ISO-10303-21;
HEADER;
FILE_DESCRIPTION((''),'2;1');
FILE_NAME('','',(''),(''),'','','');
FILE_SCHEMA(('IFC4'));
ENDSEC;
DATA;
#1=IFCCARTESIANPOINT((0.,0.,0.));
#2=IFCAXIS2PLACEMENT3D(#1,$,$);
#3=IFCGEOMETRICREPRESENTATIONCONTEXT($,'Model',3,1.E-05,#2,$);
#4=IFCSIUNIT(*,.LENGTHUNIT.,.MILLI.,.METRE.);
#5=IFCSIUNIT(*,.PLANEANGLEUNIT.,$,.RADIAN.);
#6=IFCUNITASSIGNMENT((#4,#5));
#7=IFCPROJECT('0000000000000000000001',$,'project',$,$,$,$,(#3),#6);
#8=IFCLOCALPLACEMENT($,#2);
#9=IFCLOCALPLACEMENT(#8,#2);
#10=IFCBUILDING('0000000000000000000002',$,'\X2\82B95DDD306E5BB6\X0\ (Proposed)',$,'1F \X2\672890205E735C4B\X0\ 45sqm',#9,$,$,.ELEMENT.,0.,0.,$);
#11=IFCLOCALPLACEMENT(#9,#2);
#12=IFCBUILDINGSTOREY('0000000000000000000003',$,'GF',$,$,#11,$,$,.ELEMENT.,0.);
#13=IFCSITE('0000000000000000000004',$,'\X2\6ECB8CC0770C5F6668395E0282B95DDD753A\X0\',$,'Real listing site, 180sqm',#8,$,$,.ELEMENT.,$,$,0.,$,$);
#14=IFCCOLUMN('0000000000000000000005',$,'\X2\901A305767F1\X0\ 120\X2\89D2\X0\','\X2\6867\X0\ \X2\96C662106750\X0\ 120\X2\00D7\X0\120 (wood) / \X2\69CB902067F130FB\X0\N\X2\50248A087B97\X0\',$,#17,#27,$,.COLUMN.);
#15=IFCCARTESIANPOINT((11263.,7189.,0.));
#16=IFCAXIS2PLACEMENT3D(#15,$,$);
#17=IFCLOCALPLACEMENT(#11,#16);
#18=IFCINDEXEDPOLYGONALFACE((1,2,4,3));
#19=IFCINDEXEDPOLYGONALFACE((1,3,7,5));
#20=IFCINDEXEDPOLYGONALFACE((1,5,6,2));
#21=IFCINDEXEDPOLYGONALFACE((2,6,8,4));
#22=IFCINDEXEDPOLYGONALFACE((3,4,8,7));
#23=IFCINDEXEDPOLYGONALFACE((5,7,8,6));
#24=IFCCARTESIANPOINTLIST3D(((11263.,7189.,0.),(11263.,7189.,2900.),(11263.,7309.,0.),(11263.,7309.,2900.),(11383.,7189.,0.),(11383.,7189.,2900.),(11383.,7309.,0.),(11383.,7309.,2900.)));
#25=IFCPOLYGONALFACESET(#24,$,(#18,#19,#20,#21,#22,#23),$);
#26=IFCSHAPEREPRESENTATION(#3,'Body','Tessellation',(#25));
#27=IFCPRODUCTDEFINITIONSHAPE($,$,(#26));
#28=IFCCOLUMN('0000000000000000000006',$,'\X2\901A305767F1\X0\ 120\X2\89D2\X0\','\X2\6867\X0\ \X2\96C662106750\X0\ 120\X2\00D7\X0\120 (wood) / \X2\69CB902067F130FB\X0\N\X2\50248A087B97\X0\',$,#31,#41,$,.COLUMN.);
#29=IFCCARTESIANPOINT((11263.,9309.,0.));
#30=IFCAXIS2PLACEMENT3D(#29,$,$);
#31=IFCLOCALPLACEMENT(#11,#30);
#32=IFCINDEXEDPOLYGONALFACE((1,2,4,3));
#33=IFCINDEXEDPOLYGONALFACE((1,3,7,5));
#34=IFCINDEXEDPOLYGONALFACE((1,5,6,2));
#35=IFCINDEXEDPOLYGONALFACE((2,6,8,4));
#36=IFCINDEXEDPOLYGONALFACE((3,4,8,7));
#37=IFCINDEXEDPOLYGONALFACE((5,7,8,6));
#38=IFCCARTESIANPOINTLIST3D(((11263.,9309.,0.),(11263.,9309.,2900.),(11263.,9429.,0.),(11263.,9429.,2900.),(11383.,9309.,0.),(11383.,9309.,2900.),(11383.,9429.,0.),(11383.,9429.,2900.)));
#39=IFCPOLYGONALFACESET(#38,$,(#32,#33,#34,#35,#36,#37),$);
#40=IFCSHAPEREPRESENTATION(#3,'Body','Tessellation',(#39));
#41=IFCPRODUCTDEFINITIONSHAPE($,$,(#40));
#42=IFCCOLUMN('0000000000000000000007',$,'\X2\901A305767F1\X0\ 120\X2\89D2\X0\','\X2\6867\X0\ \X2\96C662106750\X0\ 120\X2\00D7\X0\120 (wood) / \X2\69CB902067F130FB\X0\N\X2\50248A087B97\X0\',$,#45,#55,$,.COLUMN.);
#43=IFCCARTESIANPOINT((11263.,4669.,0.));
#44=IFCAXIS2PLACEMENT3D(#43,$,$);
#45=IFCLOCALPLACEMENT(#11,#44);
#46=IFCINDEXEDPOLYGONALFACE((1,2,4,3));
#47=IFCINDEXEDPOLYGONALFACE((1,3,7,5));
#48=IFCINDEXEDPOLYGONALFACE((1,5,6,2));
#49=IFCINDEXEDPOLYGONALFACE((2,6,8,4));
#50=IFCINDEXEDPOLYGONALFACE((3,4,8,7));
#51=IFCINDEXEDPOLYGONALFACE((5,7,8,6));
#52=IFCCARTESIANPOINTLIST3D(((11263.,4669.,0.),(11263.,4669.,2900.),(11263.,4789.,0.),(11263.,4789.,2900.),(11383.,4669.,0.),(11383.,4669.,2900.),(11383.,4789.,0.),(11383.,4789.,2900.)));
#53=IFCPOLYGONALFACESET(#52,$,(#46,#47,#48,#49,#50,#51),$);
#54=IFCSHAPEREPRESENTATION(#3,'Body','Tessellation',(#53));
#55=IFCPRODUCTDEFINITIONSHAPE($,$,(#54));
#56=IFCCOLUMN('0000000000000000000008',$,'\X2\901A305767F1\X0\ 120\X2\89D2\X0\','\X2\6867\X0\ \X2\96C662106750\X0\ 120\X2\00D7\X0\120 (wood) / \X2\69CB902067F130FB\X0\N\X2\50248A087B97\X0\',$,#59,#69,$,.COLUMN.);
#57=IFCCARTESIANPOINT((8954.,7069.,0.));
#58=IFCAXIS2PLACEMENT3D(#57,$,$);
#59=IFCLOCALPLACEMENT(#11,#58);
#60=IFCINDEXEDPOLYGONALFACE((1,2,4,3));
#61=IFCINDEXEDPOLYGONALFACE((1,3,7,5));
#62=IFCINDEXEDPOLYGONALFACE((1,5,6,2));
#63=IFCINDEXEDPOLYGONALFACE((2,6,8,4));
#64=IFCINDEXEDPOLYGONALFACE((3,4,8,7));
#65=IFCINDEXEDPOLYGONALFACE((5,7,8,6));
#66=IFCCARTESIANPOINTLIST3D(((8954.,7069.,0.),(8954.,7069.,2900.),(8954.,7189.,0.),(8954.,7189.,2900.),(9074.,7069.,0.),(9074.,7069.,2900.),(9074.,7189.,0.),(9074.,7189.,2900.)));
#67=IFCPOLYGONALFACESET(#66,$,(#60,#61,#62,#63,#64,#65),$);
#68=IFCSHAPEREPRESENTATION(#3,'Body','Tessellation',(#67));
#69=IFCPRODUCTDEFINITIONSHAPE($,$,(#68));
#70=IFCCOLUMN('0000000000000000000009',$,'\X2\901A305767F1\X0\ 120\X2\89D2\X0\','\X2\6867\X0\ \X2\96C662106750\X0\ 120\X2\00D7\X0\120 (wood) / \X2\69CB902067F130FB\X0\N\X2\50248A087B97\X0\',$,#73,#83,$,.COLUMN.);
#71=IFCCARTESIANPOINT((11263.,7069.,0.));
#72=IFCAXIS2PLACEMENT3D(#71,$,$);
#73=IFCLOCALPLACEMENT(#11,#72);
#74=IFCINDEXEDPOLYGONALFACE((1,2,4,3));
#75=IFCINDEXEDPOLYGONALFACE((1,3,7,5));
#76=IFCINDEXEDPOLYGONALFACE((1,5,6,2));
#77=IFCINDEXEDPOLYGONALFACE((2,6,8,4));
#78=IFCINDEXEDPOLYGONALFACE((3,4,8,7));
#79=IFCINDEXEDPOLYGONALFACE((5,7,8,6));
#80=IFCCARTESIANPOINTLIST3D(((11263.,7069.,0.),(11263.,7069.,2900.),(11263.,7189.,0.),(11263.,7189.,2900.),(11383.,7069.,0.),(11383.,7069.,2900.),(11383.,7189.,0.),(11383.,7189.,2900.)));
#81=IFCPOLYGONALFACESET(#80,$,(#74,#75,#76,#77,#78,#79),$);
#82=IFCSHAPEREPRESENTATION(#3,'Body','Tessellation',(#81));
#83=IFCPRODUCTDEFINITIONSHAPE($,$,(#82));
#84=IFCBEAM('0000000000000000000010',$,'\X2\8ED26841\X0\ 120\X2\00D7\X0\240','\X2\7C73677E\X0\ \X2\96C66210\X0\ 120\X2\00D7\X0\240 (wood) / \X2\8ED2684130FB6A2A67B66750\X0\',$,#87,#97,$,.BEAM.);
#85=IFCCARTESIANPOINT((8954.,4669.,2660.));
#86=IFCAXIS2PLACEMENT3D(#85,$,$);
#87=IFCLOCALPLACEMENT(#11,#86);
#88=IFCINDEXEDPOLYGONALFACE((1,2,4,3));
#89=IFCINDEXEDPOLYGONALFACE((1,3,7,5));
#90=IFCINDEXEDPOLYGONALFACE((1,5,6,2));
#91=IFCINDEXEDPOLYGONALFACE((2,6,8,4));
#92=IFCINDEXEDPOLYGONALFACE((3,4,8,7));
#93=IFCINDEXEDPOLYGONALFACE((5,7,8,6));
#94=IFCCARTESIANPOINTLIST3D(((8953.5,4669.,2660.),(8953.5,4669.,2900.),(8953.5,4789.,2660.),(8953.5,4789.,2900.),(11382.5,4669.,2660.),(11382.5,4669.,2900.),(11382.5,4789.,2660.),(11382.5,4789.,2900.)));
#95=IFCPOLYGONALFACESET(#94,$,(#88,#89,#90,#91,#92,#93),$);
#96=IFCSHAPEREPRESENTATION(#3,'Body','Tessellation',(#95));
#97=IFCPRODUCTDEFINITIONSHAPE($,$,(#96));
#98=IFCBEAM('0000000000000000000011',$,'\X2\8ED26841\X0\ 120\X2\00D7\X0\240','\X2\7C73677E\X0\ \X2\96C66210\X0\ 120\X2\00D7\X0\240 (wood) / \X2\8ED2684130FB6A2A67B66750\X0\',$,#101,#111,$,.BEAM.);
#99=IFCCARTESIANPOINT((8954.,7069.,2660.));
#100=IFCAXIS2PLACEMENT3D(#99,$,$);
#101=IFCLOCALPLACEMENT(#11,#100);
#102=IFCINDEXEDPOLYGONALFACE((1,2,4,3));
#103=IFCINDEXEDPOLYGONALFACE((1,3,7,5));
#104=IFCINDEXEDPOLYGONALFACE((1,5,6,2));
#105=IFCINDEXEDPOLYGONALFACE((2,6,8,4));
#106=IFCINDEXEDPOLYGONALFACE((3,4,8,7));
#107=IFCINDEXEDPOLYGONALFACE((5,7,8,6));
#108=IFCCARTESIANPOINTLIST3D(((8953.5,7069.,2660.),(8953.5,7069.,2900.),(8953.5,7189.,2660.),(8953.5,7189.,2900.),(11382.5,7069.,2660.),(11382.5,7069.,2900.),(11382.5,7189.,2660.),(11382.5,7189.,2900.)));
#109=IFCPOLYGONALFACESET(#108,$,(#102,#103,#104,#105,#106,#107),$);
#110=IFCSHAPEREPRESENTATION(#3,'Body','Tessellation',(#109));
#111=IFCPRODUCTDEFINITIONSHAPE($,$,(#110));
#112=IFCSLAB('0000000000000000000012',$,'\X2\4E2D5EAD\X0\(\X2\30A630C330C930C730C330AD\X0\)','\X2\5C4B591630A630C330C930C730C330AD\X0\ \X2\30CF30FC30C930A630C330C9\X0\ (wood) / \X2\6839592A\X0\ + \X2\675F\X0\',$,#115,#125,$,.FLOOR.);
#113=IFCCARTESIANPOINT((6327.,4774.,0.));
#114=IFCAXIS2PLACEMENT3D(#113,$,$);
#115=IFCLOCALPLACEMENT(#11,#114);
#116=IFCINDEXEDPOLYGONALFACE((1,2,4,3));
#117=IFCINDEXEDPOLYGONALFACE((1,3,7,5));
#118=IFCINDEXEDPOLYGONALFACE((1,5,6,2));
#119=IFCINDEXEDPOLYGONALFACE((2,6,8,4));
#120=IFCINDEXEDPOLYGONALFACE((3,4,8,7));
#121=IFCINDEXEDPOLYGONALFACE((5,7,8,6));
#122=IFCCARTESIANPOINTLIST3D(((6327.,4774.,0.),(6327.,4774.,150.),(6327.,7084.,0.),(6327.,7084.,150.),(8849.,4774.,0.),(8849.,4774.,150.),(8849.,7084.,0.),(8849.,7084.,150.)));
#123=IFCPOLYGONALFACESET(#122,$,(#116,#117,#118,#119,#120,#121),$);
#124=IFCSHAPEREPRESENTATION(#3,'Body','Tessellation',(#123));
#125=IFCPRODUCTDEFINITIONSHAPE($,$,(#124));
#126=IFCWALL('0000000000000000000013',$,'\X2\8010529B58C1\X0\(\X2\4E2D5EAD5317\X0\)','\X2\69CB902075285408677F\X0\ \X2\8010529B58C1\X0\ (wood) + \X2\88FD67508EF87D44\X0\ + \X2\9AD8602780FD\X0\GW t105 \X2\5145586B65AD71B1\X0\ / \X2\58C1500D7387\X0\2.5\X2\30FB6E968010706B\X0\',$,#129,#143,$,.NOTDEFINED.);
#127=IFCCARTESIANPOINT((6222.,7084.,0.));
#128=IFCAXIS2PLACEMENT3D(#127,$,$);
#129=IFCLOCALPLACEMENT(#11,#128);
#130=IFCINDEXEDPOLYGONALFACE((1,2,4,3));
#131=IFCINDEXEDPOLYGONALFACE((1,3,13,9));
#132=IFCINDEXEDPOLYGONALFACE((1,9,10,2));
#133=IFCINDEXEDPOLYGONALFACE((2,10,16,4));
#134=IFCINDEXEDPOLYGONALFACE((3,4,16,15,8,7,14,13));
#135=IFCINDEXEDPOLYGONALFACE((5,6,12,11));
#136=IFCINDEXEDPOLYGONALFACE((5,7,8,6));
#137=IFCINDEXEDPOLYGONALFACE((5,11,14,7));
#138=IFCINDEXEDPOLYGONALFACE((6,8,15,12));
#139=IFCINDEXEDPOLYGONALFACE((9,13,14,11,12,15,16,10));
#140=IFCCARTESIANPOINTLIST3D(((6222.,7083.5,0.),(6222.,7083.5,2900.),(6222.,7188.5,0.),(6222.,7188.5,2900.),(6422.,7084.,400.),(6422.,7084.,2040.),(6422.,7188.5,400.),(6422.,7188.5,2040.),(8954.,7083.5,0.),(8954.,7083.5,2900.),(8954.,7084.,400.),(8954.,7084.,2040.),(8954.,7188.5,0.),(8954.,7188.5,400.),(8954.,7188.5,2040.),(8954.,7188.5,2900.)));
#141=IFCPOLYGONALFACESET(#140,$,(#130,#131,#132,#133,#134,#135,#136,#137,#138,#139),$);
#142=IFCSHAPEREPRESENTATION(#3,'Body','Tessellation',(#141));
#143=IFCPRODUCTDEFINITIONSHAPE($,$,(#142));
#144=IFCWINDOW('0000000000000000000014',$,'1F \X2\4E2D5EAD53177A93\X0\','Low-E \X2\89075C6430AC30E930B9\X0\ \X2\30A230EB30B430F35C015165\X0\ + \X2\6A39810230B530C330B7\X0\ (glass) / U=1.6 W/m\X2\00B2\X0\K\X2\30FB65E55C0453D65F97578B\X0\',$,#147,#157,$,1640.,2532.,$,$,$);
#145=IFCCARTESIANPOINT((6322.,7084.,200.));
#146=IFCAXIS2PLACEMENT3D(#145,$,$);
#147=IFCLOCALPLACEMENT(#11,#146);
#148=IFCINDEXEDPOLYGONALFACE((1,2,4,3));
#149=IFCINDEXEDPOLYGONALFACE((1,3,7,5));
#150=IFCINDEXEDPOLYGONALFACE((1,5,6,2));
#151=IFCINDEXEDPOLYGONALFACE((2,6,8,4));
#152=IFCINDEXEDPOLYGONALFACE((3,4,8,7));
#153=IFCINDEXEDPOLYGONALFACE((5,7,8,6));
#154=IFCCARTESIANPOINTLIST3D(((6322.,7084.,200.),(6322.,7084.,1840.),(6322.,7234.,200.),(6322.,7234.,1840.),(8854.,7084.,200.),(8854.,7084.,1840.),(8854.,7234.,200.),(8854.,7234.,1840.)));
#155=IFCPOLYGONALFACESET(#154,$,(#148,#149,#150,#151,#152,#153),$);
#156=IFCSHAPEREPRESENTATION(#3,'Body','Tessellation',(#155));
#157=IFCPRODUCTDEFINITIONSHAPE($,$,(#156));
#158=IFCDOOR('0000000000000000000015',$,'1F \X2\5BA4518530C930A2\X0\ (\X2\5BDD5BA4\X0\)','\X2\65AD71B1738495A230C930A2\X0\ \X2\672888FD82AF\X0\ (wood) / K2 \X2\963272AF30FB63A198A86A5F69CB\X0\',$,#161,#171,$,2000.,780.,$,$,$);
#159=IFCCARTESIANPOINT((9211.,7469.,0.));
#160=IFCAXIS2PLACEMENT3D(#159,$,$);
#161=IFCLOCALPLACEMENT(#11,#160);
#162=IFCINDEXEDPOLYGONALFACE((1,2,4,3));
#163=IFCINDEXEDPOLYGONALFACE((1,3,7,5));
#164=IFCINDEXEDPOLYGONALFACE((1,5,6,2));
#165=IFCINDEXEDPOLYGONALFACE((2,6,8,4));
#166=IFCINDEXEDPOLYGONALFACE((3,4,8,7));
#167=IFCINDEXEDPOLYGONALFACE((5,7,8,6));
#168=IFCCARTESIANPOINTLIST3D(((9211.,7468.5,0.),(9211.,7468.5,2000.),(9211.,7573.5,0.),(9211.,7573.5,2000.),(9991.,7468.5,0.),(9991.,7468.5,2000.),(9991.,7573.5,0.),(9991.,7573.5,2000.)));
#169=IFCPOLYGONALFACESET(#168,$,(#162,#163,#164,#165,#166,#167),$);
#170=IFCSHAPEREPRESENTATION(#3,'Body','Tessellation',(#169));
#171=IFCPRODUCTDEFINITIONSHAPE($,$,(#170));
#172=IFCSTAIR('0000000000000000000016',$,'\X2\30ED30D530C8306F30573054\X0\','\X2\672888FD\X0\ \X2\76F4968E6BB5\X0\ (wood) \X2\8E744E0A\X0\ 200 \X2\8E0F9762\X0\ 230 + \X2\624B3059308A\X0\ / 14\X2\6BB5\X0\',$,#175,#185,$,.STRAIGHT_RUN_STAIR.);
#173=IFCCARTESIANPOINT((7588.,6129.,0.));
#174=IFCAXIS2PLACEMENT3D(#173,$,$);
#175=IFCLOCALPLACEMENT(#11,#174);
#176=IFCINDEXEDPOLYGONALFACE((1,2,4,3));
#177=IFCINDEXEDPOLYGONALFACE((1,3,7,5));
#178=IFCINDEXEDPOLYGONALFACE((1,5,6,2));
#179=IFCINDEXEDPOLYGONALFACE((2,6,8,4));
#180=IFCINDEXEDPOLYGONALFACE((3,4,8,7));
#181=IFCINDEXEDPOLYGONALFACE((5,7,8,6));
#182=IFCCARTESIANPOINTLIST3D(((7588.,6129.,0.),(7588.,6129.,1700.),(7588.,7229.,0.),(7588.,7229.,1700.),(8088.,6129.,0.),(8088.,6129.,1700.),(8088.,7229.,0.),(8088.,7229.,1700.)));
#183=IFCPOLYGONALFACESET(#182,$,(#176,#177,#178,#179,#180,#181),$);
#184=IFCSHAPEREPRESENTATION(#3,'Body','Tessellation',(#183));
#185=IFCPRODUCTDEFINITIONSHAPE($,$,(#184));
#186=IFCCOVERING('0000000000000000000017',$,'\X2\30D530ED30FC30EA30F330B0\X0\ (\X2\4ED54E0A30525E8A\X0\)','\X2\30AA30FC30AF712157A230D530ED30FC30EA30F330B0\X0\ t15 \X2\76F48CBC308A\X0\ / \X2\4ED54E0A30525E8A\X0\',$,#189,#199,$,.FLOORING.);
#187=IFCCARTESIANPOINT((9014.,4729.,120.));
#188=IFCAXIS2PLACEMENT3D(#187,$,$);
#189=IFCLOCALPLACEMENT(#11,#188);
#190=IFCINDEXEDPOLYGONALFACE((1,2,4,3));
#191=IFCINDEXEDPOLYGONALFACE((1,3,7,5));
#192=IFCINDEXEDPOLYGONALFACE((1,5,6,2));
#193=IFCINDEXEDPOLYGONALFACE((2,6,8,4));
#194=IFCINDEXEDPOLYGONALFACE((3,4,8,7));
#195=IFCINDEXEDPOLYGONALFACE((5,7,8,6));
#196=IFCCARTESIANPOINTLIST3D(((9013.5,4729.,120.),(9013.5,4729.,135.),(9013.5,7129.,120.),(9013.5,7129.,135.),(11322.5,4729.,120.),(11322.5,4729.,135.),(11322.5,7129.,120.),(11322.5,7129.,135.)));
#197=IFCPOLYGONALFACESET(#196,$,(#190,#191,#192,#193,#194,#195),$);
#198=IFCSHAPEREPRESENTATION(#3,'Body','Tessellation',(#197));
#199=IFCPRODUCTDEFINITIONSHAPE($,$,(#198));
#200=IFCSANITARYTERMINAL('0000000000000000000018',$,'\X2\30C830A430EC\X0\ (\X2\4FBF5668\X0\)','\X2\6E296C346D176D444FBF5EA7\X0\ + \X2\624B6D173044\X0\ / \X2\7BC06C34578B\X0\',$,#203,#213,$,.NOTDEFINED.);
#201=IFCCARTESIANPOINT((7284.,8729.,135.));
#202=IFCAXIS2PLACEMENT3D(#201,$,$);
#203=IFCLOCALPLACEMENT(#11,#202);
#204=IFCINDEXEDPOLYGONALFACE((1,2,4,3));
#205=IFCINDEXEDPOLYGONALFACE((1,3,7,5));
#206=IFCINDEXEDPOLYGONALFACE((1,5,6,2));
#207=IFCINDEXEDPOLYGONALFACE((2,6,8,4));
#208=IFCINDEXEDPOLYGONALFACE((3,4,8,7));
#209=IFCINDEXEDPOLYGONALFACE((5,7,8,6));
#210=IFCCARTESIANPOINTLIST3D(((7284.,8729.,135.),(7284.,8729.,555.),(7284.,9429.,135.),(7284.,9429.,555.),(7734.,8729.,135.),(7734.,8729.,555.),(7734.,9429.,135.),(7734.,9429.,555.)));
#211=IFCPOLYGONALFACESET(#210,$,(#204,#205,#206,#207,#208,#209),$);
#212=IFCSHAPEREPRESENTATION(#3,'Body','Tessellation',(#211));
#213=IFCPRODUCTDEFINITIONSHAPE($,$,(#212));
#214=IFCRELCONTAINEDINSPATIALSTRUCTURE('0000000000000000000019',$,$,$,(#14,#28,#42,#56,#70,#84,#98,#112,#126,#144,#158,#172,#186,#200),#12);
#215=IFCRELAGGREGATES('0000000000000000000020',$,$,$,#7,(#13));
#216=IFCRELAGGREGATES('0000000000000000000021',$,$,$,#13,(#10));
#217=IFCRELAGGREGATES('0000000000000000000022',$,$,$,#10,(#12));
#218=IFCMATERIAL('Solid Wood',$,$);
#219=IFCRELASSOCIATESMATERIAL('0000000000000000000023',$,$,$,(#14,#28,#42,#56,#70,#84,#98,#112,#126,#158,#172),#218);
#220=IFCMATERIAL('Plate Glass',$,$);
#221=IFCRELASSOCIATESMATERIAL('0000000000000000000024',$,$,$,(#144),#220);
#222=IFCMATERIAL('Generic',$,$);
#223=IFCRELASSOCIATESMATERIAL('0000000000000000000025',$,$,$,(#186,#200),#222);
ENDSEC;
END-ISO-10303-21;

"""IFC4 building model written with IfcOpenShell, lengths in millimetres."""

from ifc_helpers import new_model, si_unit, frame, frame_2d, origin, place, context, project, spatial, rectangle, extrude, material, element, fill, save


model = new_model("IFC4")

# Units and contexts
model_context = context("Model", 3, precision=1e-05, world=origin())
ifc_project = project(units=[si_unit("LENGTHUNIT", "METRE", prefix="MILLI"), si_unit("PLANEANGLEUNIT", "RADIAN")], contexts=[model_context])

# Site, building, storey
site_placement = place(None, origin())
site = spatial("IfcSite", under=ifc_project, at=site_placement, Name="滋賀県彦根市芹川町", ObjectType="Real listing site, 180sqm", CompositionType="ELEMENT", RefElevation=0.0)
building_placement = place(site_placement, origin())
building = spatial("IfcBuilding", under=site, at=building_placement, Name="芹川の家 (Proposed)", ObjectType="1F 木造平屋 45sqm", CompositionType="ELEMENT", ElevationOfRefHeight=0.0, ElevationOfTerrain=0.0)
storey_placement = place(building_placement, origin())
storey = spatial("IfcBuildingStorey", under=building, at=storey_placement, Name="GF", CompositionType="ELEMENT", Elevation=0.0)

# Columns
ifc_material_1 = material(Name="Solid Wood")
column_1_placement = place(storey_placement, frame((11263.0, 7189.0, 0.0)))
element("IfcColumn", 1, at=column_1_placement, inside=storey, material=ifc_material_1, Name="通し柱 120角", Description="桧 集成材 120×120 (wood) / 構造柱・N値計算", PredefinedType="COLUMN", context=model_context, shape_type="SweptSolid", body=[
    extrude(rectangle(XDim=120.0, YDim=120.0, at=frame_2d((60.0, 60.0))), frame((11263.0, 7189.0, 0.0)), (0.0, 0.0, 1.0), 2900.0),
])
column_2_placement = place(storey_placement, frame((11263.0, 9309.0, 0.0)))
element("IfcColumn", 2, at=column_2_placement, inside=storey, material=ifc_material_1, Name="通し柱 120角", Description="桧 集成材 120×120 (wood) / 構造柱・N値計算", PredefinedType="COLUMN", context=model_context, shape_type="SweptSolid", body=[
    extrude(rectangle(XDim=120.0, YDim=120.0, at=frame_2d((60.0, 60.0))), frame((11263.0, 9309.0, 0.0)), (0.0, 0.0, 1.0), 2900.0),
])
column_3_placement = place(storey_placement, frame((11263.0, 4669.0, 0.0)))
element("IfcColumn", 3, at=column_3_placement, inside=storey, material=ifc_material_1, Name="通し柱 120角", Description="桧 集成材 120×120 (wood) / 構造柱・N値計算", PredefinedType="COLUMN", context=model_context, shape_type="SweptSolid", body=[
    extrude(rectangle(XDim=120.0, YDim=120.0, at=frame_2d((60.0, 60.0))), frame((11263.0, 4669.0, 0.0)), (0.0, 0.0, 1.0), 2900.0),
])
column_4_placement = place(storey_placement, frame((8954.0, 7069.0, 0.0)))
element("IfcColumn", 4, at=column_4_placement, inside=storey, material=ifc_material_1, Name="通し柱 120角", Description="桧 集成材 120×120 (wood) / 構造柱・N値計算", PredefinedType="COLUMN", context=model_context, shape_type="SweptSolid", body=[
    extrude(rectangle(XDim=120.0, YDim=120.0, at=frame_2d((60.0, 60.0))), frame((8954.0, 7069.0, 0.0)), (0.0, 0.0, 1.0), 2900.0),
])
column_5_placement = place(storey_placement, frame((11263.0, 7069.0, 0.0)))
element("IfcColumn", 5, at=column_5_placement, inside=storey, material=ifc_material_1, Name="通し柱 120角", Description="桧 集成材 120×120 (wood) / 構造柱・N値計算", PredefinedType="COLUMN", context=model_context, shape_type="SweptSolid", body=[
    extrude(rectangle(XDim=120.0, YDim=120.0, at=frame_2d((60.0, 60.0))), frame((11263.0, 7069.0, 0.0)), (0.0, 0.0, 1.0), 2900.0),
])

# Beams
beam_1_placement = place(storey_placement, frame((8954.0, 4669.0, 2660.0)))
element("IfcBeam", 6, at=beam_1_placement, inside=storey, material=ifc_material_1, Name="軒桁 120×240", Description="米松 集成 120×240 (wood) / 軒桁・横架材", PredefinedType="BEAM", context=model_context, shape_type="SweptSolid", body=[
    extrude(rectangle(XDim=2429.0, YDim=120.0, at=frame_2d((1214.0, 60.0))), frame((8954.0, 4669.0, 2660.0)), (0.0, 0.0, 1.0), 240.0),
])
beam_2_placement = place(storey_placement, frame((8954.0, 7069.0, 2660.0)))
element("IfcBeam", 7, at=beam_2_placement, inside=storey, material=ifc_material_1, Name="軒桁 120×240", Description="米松 集成 120×240 (wood) / 軒桁・横架材", PredefinedType="BEAM", context=model_context, shape_type="SweptSolid", body=[
    extrude(rectangle(XDim=2429.0, YDim=120.0, at=frame_2d((1214.0, 60.0))), frame((8954.0, 7069.0, 2660.0)), (0.0, 0.0, 1.0), 240.0),
])

# Slab
slab_placement = place(storey_placement, frame((6327.0, 4774.0, 0.0)))
element("IfcSlab", 8, at=slab_placement, inside=storey, material=ifc_material_1, Name="中庭(ウッドデッキ)", Description="屋外ウッドデッキ ハードウッド (wood) / 根太 + 束", PredefinedType="FLOOR", context=model_context, shape_type="SweptSolid", body=[
    extrude(rectangle(XDim=2522.0, YDim=2310.0, at=frame_2d((1261.0, 1155.0))), frame((6327.0, 4774.0, 0.0)), (0.0, 0.0, 1.0), 150.0),
])

# Wall, opening, window
wall_1_placement = place(storey_placement, frame((6222.0, 7084.0, 0.0)))
wall_1 = element("IfcWall", 9, at=wall_1_placement, inside=storey, material=ifc_material_1, Name="耐力壁(中庭北)", Description="構造用合板 耐力壁 (wood) + 製材軸組 + 高性能GW t105 充填断熱 / 壁倍率2.5・準耐火", PredefinedType="NOTDEFINED", context=model_context, shape_type="SweptSolid", body=[
    extrude(rectangle(XDim=2732.0, YDim=105.0, at=frame_2d((1366.0, 52.0))), frame((6222.0, 7084.0, 0.0)), (0.0, 0.0, 1.0), 2900.0),
])
opening_placement = place(storey_placement, frame((6322.0, 7084.0, 200.0)))
opening = element("IfcOpeningElement", 10, at=opening_placement, cuts=wall_1, PredefinedType="NOTDEFINED", context=model_context, shape_type="SweptSolid", body=[
    extrude(rectangle(XDim=2532.0, YDim=150.0, at=frame_2d((1266.0, 75.0))), frame((6322.0, 7084.0, 200.0)), (0.0, 0.0, 1.0), 1640.0),
])
ifc_material_2 = material(Name="Plate Glass")
window_placement = place(storey_placement, frame((6322.0, 7084.0, 200.0)))
window = element("IfcWindow", 11, at=window_placement, inside=storey, material=ifc_material_2, Name="1F 中庭北窓", Description="Low-E 複層ガラス アルゴン封入 + 樹脂サッシ (glass) / U=1.6 W/m²K・日射取得型", OverallHeight=1640.0, OverallWidth=2532.0, context=model_context, shape_type="SweptSolid", body=[
    extrude(rectangle(XDim=2532.0, YDim=150.0, at=frame_2d((1266.0, 75.0))), frame((6322.0, 7084.0, 200.0)), (0.0, 0.0, 1.0), 1640.0),
])
fill(opening, window)

# Door
door_placement = place(storey_placement, frame((9211.0, 7469.0, 0.0)))
element("IfcDoor", 12, at=door_placement, inside=storey, material=ifc_material_1, Name="1F 室内ドア (寝室)", Description="断熱玄関ドア 木製芯 (wood) / K2 防犯・採風機構", OverallHeight=2000.0, OverallWidth=780.0, context=model_context, shape_type="SweptSolid", body=[
    extrude(rectangle(XDim=780.0, YDim=105.0, at=frame_2d((390.0, 52.0))), frame((9211.0, 7469.0, 0.0)), (0.0, 0.0, 1.0), 2000.0),
])

# Stair
stair_placement = place(storey_placement, frame((7588.0, 6129.0, 0.0)))
element("IfcStair", 13, at=stair_placement, inside=storey, material=ifc_material_1, Name="ロフトはしご", Description="木製 直階段 (wood) 蹴上 200 踏面 230 + 手すり / 14段", PredefinedType="STRAIGHT_RUN_STAIR", context=model_context, shape_type="SweptSolid", body=[
    extrude(rectangle(XDim=500.0, YDim=1100.0, at=frame_2d((250.0, 550.0))), frame((7588.0, 6129.0, 0.0)), (0.0, 0.0, 1.0), 1700.0),
])

# Covering
ifc_material_3 = material(Name="Generic")
covering_placement = place(storey_placement, frame((9014.0, 4729.0, 120.0)))
element("IfcCovering", 14, at=covering_placement, inside=storey, material=ifc_material_3, Name="フローリング (仕上げ床)", Description="オーク無垢フローリング t15 直貼り / 仕上げ床", PredefinedType="FLOORING", context=model_context, shape_type="SweptSolid", body=[
    extrude(rectangle(XDim=2309.0, YDim=2400.0, at=frame_2d((1154.0, 1200.0))), frame((9014.0, 4729.0, 120.0)), (0.0, 0.0, 1.0), 15.0),
])

# Sanitary terminal
sanitary_terminal_placement = place(storey_placement, frame((7284.0, 8729.0, 135.0)))
element("IfcSanitaryTerminal", 15, at=sanitary_terminal_placement, inside=storey, material=ifc_material_3, Name="トイレ (便器)", Description="温水洗浄便座 + 手洗い / 節水型", PredefinedType="NOTDEFINED", context=model_context, shape_type="SweptSolid", body=[
    extrude(rectangle(XDim=450.0, YDim=700.0, at=frame_2d((225.0, 350.0))), frame((7284.0, 8729.0, 135.0)), (0.0, 0.0, 1.0), 420.0),
])

save(model, "model.ifc")
